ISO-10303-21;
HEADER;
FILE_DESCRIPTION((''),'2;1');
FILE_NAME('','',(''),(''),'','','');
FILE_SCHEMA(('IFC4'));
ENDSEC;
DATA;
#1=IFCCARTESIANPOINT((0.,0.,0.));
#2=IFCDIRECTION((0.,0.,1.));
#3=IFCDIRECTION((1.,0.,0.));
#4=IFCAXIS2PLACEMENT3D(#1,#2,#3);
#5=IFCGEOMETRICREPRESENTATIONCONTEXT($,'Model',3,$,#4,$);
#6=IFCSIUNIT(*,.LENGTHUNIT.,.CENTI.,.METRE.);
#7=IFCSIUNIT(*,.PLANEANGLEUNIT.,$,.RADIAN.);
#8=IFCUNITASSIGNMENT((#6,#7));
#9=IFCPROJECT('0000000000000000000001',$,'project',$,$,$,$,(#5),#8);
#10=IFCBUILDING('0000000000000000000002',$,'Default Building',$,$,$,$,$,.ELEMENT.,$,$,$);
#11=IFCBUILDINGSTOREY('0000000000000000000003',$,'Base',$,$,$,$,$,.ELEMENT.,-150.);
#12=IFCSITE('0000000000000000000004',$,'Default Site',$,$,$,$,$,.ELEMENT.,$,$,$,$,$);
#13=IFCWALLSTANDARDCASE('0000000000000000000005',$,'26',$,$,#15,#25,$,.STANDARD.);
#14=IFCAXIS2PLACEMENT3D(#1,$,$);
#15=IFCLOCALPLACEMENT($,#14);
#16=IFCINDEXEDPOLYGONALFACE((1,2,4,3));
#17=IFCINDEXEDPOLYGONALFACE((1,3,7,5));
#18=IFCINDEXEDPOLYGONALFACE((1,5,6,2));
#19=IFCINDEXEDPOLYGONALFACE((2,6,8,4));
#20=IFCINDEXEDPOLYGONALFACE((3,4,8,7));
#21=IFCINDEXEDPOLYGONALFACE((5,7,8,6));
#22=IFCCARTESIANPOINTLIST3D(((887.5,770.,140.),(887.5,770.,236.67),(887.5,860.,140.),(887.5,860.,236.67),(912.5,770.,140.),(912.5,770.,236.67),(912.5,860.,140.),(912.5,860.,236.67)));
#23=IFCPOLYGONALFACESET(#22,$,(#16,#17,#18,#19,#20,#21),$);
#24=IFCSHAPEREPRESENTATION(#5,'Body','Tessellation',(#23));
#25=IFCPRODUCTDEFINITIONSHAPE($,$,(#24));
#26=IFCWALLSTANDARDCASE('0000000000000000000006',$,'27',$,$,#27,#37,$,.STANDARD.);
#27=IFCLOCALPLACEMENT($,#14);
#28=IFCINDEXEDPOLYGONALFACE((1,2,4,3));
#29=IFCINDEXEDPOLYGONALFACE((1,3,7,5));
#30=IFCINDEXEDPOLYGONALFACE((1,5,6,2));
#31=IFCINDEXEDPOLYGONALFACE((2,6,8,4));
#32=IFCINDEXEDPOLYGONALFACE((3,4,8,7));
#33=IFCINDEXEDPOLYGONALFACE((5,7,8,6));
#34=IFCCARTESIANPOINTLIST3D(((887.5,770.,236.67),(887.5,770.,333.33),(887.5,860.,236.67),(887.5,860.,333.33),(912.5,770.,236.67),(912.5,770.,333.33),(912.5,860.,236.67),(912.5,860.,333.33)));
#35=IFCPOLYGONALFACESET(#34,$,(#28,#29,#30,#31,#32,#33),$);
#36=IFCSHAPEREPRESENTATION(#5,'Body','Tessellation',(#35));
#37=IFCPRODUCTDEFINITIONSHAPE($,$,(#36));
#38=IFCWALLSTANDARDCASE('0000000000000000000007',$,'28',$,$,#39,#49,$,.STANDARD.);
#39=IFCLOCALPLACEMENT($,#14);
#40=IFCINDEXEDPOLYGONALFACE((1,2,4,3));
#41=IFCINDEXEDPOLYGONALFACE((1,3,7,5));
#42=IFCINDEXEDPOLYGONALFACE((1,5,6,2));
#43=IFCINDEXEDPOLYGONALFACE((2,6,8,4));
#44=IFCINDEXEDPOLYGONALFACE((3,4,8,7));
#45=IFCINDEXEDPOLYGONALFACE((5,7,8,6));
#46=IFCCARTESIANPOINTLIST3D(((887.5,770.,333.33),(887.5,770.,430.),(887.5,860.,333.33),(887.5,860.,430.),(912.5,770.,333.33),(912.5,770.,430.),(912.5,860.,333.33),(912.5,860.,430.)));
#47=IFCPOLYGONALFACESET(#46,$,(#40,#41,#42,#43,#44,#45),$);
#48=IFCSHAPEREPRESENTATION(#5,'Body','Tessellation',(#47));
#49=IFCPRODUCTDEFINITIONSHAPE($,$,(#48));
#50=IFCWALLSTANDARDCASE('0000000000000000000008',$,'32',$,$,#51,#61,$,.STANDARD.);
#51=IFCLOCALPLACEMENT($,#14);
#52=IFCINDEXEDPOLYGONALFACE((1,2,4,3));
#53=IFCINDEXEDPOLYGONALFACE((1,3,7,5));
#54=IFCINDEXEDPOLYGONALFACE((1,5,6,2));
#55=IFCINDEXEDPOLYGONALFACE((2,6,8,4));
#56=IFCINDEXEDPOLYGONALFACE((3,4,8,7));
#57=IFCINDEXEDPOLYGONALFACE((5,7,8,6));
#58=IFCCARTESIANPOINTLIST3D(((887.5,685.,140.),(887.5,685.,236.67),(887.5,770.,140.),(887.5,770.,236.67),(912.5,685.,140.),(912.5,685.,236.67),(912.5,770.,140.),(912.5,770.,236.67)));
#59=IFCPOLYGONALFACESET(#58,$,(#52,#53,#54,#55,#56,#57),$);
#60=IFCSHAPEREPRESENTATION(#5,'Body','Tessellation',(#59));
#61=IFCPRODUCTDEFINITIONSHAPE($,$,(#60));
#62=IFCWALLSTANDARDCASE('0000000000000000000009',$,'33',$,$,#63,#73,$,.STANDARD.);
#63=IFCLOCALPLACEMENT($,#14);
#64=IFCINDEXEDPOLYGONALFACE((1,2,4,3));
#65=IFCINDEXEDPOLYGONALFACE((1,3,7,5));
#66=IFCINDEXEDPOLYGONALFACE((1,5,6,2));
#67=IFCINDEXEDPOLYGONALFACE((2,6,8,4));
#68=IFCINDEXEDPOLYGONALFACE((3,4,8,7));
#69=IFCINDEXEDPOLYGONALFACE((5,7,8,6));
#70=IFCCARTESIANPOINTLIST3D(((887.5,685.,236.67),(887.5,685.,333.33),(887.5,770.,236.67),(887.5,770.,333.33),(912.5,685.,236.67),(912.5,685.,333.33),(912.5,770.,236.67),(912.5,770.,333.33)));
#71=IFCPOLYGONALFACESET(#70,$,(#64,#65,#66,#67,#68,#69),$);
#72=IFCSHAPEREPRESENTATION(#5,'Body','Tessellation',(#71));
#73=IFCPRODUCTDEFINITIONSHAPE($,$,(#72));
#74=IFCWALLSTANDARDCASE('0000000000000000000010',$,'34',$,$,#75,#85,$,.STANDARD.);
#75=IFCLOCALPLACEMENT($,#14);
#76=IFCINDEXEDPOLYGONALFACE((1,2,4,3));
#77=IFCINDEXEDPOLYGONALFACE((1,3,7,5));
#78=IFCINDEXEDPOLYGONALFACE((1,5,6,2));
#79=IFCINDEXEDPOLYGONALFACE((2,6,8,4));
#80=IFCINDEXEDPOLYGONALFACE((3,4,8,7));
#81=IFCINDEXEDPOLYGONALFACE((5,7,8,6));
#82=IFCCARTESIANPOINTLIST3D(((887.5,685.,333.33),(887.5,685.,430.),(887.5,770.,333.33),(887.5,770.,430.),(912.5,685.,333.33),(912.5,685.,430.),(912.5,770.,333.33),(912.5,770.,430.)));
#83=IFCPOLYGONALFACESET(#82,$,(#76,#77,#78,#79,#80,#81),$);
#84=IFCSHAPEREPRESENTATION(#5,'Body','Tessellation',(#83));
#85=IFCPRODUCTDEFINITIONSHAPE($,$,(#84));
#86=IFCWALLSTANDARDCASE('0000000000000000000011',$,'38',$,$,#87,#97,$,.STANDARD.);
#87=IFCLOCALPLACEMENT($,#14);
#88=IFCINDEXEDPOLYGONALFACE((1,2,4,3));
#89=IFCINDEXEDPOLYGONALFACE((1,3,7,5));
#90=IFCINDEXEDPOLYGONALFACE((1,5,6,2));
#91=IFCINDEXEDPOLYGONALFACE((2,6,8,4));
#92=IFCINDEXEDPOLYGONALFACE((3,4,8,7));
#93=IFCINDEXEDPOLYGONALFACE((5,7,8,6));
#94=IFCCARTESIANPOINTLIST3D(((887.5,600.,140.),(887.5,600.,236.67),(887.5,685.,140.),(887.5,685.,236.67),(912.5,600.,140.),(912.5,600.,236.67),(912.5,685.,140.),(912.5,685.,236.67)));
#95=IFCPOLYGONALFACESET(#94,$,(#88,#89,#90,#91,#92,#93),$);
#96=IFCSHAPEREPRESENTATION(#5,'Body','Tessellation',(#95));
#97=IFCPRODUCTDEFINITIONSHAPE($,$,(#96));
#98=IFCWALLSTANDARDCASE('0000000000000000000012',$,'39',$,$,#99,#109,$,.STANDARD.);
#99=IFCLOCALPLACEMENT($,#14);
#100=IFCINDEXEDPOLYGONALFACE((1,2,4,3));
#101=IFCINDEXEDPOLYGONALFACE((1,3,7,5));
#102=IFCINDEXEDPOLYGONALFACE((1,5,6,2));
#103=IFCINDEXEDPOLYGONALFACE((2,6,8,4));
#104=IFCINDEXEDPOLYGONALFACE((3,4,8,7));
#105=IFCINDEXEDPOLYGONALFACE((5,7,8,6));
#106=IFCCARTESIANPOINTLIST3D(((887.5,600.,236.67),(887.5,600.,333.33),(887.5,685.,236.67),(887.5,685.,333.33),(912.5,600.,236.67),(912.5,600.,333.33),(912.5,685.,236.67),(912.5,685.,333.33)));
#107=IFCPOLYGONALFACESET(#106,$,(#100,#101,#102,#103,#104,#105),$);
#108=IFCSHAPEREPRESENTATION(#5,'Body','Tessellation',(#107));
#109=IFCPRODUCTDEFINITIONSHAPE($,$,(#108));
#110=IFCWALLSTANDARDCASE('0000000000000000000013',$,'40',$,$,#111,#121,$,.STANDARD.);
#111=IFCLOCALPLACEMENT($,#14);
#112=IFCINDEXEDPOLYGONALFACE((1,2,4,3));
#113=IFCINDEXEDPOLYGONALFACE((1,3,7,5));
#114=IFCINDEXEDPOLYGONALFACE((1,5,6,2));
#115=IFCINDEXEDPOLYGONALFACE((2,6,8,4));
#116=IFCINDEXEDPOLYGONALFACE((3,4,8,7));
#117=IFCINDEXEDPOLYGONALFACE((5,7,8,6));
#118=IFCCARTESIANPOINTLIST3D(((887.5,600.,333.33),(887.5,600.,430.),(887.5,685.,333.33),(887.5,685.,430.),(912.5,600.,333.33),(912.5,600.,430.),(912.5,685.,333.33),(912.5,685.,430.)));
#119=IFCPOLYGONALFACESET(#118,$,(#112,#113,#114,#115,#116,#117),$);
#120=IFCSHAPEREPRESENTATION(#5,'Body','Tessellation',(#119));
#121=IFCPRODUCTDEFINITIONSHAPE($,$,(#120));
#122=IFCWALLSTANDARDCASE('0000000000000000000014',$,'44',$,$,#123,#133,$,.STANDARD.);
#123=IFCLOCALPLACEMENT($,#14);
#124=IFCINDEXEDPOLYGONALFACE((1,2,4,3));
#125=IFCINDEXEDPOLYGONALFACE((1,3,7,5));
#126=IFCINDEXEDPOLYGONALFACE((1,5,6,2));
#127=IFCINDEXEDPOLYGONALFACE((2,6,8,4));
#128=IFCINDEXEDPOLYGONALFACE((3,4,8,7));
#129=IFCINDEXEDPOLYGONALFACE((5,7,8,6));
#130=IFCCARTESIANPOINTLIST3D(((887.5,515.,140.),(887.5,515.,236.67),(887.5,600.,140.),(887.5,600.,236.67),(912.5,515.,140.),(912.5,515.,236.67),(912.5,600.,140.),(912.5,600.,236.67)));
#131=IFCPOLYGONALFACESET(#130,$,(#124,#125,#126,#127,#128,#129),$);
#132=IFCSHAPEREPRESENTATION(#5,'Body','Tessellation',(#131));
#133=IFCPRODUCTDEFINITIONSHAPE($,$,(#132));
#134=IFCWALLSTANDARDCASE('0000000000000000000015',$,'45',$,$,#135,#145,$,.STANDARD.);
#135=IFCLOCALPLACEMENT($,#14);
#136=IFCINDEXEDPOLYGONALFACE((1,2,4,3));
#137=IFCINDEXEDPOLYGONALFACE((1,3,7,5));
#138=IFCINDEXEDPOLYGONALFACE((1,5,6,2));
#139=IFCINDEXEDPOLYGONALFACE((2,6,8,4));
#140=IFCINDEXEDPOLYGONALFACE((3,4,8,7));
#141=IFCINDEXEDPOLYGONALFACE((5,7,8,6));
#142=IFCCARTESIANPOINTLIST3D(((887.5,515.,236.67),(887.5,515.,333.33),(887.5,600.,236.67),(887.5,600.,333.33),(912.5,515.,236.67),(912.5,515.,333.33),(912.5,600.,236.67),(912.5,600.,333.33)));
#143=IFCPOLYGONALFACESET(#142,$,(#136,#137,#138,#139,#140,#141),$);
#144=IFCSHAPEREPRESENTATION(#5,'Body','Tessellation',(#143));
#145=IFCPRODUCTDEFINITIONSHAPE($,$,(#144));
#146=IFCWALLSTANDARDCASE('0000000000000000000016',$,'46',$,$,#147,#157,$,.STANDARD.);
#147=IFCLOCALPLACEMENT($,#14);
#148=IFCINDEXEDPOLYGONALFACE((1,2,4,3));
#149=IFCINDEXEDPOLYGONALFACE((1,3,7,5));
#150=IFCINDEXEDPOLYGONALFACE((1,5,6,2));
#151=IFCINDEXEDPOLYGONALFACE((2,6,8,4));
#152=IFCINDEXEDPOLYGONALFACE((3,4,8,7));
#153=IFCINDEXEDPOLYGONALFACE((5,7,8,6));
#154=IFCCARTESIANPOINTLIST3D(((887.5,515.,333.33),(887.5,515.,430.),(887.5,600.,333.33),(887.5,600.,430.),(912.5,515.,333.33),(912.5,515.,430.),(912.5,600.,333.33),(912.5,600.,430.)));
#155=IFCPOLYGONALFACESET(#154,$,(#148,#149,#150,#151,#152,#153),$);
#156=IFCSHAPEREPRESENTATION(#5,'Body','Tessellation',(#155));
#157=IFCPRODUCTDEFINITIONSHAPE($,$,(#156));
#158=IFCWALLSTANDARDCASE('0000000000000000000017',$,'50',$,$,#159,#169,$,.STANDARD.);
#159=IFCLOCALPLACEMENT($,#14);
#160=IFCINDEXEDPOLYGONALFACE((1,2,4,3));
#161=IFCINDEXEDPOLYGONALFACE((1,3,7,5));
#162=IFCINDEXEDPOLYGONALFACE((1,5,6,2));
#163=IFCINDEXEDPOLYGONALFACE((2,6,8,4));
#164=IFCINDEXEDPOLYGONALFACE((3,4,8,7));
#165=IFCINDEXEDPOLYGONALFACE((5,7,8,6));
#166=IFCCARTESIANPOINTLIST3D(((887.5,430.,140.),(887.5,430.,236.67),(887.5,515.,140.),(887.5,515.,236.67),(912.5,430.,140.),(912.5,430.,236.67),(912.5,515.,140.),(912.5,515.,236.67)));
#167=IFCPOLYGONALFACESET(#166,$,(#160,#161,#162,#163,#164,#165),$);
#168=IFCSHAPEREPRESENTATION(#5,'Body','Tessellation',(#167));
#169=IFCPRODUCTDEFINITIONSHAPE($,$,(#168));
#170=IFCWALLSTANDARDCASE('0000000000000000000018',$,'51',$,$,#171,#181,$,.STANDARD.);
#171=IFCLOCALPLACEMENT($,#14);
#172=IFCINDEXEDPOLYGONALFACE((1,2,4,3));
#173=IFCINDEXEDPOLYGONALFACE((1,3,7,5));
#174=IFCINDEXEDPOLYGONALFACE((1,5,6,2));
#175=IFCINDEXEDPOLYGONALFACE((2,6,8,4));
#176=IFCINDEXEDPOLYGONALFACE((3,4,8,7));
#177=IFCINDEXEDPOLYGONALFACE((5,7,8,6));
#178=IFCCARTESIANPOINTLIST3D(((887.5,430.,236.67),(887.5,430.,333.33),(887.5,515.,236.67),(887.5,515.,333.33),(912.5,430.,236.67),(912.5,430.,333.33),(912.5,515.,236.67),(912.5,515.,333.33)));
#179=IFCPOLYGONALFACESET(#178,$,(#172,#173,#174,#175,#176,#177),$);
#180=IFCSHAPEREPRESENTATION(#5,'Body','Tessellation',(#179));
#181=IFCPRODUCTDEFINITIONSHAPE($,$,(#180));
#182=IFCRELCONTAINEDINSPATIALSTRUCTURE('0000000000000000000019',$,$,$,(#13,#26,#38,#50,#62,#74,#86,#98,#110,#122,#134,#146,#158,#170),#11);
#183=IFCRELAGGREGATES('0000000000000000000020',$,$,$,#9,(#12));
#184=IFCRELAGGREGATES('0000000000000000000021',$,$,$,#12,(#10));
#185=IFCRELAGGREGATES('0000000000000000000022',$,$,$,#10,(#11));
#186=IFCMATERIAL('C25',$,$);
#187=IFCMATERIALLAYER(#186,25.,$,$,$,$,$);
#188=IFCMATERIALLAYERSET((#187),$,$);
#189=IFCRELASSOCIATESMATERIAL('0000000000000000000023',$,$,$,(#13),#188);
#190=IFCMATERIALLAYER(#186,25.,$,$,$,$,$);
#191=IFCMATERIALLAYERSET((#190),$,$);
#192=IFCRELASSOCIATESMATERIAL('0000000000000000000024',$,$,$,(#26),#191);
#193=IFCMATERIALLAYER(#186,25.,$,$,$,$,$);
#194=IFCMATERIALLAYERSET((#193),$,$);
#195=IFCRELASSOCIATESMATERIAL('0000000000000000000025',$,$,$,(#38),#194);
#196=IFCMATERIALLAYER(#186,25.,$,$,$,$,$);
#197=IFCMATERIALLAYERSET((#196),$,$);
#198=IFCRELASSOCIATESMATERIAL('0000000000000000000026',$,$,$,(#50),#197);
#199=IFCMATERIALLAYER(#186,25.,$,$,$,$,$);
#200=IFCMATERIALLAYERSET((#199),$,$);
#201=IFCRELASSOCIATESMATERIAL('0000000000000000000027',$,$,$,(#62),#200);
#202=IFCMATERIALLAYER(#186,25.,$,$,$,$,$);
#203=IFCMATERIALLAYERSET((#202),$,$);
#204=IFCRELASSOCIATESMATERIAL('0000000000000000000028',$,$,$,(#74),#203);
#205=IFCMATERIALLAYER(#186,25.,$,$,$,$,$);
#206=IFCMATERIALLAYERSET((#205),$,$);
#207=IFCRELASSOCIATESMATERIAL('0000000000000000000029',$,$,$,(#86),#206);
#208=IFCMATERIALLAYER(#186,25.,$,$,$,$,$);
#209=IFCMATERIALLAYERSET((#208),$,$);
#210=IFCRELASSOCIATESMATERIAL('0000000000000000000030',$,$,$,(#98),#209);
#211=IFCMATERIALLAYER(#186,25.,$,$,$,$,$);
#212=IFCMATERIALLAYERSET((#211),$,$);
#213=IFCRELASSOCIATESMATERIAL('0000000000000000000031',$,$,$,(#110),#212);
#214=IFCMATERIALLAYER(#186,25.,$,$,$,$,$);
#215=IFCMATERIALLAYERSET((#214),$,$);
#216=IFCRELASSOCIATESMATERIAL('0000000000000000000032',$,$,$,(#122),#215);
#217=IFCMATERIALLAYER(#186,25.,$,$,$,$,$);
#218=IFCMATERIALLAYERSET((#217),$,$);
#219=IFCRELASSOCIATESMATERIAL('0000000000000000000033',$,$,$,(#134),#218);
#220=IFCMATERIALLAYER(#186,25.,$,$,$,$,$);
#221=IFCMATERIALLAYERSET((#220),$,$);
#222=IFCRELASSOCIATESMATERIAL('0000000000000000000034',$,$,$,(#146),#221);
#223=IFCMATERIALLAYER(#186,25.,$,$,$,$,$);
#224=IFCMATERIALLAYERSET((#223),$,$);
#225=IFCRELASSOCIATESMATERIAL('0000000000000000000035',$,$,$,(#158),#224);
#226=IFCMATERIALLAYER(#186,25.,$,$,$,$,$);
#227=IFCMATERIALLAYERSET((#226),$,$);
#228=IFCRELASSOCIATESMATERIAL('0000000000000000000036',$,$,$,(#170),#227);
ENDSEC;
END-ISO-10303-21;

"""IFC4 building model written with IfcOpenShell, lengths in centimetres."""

from ifc_helpers import new_model, si_unit, frame, origin_with_axes, origin_2d_with_axis, place, context, project, spatial, rectangle, extrude, material, layer, layer_set, layer_usage, element, save


model = new_model("IFC4")

# Units and contexts
model_context = context("Model", 3, world=origin_with_axes())
ifc_project = project(units=[si_unit("LENGTHUNIT", "METRE", prefix="CENTI"), si_unit("PLANEANGLEUNIT", "RADIAN")], contexts=[model_context])

# Site, building, storey
site = spatial("IfcSite", under=ifc_project, Name="Default Site", CompositionType="ELEMENT")
building = spatial("IfcBuilding", under=site, Name="Default Building", CompositionType="ELEMENT")
storey = spatial("IfcBuildingStorey", under=building, Name="Base", CompositionType="ELEMENT", Elevation=-150.0)

# Walls
ifc_material = material(Name="C25")
ifc_layer_1 = layer(ifc_material, 25.0)
ifc_layer_set_1 = layer_set([ifc_layer_1])
ifc_layer_usage_1 = layer_usage(ifc_layer_set_1, "AXIS2", "POSITIVE", -25.0)
wall_1_placement = place(None, frame((900.0, 815.0, 140.0), z_axis=(0.0, 0.0, 1.0), x_axis=(0.0, -1.0, 0.0)))
element("IfcWallStandardCase", 1, at=wall_1_placement, inside=storey, material=ifc_layer_usage_1, Name="26", PredefinedType="STANDARD", context=model_context, shape_type="SweptSolid", body=[
    extrude(rectangle(XDim=90.0, YDim=25.0, at=origin_2d_with_axis()), origin_with_axes(), (0.0, 0.0, 1.0), 96.67),
])
ifc_layer_2 = layer(ifc_material, 25.0)
ifc_layer_set_2 = layer_set([ifc_layer_2])
ifc_layer_usage_2 = layer_usage(ifc_layer_set_2, "AXIS2", "POSITIVE", -25.0)
wall_2_placement = place(None, frame((900.0, 815.0, 236.67), z_axis=(0.0, 0.0, 1.0), x_axis=(0.0, -1.0, 0.0)))
element("IfcWallStandardCase", 2, at=wall_2_placement, inside=storey, material=ifc_layer_usage_2, Name="27", PredefinedType="STANDARD", context=model_context, shape_type="SweptSolid", body=[
    extrude(rectangle(XDim=90.0, YDim=25.0, at=origin_2d_with_axis()), origin_with_axes(), (0.0, 0.0, 1.0), 96.67),
])
ifc_layer_3 = layer(ifc_material, 25.0)
ifc_layer_set_3 = layer_set([ifc_layer_3])
ifc_layer_usage_3 = layer_usage(ifc_layer_set_3, "AXIS2", "POSITIVE", -25.0)
wall_3_placement = place(None, frame((900.0, 815.0, 333.33), z_axis=(0.0, 0.0, 1.0), x_axis=(0.0, -1.0, 0.0)))
element("IfcWallStandardCase", 3, at=wall_3_placement, inside=storey, material=ifc_layer_usage_3, Name="28", PredefinedType="STANDARD", context=model_context, shape_type="SweptSolid", body=[
    extrude(rectangle(XDim=90.0, YDim=25.0, at=origin_2d_with_axis()), origin_with_axes(), (0.0, 0.0, 1.0), 96.67),
])
ifc_layer_4 = layer(ifc_material, 25.0)
ifc_layer_set_4 = layer_set([ifc_layer_4])
ifc_layer_usage_4 = layer_usage(ifc_layer_set_4, "AXIS2", "POSITIVE", -25.0)
wall_4_placement = place(None, frame((900.0, 727.5, 140.0), z_axis=(0.0, 0.0, 1.0), x_axis=(0.0, -1.0, 0.0)))
element("IfcWallStandardCase", 4, at=wall_4_placement, inside=storey, material=ifc_layer_usage_4, Name="32", PredefinedType="STANDARD", context=model_context, shape_type="SweptSolid", body=[
    extrude(rectangle(XDim=85.0, YDim=25.0, at=origin_2d_with_axis()), origin_with_axes(), (0.0, 0.0, 1.0), 96.67),
])
ifc_layer_5 = layer(ifc_material, 25.0)
ifc_layer_set_5 = layer_set([ifc_layer_5])
ifc_layer_usage_5 = layer_usage(ifc_layer_set_5, "AXIS2", "POSITIVE", -25.0)
wall_5_placement = place(None, frame((900.0, 727.5, 236.67), z_axis=(0.0, 0.0, 1.0), x_axis=(0.0, -1.0, 0.0)))
element("IfcWallStandardCase", 5, at=wall_5_placement, inside=storey, material=ifc_layer_usage_5, Name="33", PredefinedType="STANDARD", context=model_context, shape_type="SweptSolid", body=[
    extrude(rectangle(XDim=85.0, YDim=25.0, at=origin_2d_with_axis()), origin_with_axes(), (0.0, 0.0, 1.0), 96.67),
])
ifc_layer_6 = layer(ifc_material, 25.0)
ifc_layer_set_6 = layer_set([ifc_layer_6])
ifc_layer_usage_6 = layer_usage(ifc_layer_set_6, "AXIS2", "POSITIVE", -25.0)
wall_6_placement = place(None, frame((900.0, 727.5, 333.33), z_axis=(0.0, 0.0, 1.0), x_axis=(0.0, -1.0, 0.0)))
element("IfcWallStandardCase", 6, at=wall_6_placement, inside=storey, material=ifc_layer_usage_6, Name="34", PredefinedType="STANDARD", context=model_context, shape_type="SweptSolid", body=[
    extrude(rectangle(XDim=85.0, YDim=25.0, at=origin_2d_with_axis()), origin_with_axes(), (0.0, 0.0, 1.0), 96.67),
])
ifc_layer_7 = layer(ifc_material, 25.0)
ifc_layer_set_7 = layer_set([ifc_layer_7])
ifc_layer_usage_7 = layer_usage(ifc_layer_set_7, "AXIS2", "POSITIVE", -25.0)
wall_7_placement = place(None, frame((900.0, 642.5, 140.0), z_axis=(0.0, 0.0, 1.0), x_axis=(0.0, -1.0, 0.0)))
element("IfcWallStandardCase", 7, at=wall_7_placement, inside=storey, material=ifc_layer_usage_7, Name="38", PredefinedType="STANDARD", context=model_context, shape_type="SweptSolid", body=[
    extrude(rectangle(XDim=85.0, YDim=25.0, at=origin_2d_with_axis()), origin_with_axes(), (0.0, 0.0, 1.0), 96.67),
])
ifc_layer_8 = layer(ifc_material, 25.0)
ifc_layer_set_8 = layer_set([ifc_layer_8])
ifc_layer_usage_8 = layer_usage(ifc_layer_set_8, "AXIS2", "POSITIVE", -25.0)
wall_8_placement = place(None, frame((900.0, 642.5, 236.67), z_axis=(0.0, 0.0, 1.0), x_axis=(0.0, -1.0, 0.0)))
element("IfcWallStandardCase", 8, at=wall_8_placement, inside=storey, material=ifc_layer_usage_8, Name="39", PredefinedType="STANDARD", context=model_context, shape_type="SweptSolid", body=[
    extrude(rectangle(XDim=85.0, YDim=25.0, at=origin_2d_with_axis()), origin_with_axes(), (0.0, 0.0, 1.0), 96.67),
])
ifc_layer_9 = layer(ifc_material, 25.0)
ifc_layer_set_9 = layer_set([ifc_layer_9])
ifc_layer_usage_9 = layer_usage(ifc_layer_set_9, "AXIS2", "POSITIVE", -25.0)
wall_9_placement = place(None, frame((900.0, 642.5, 333.33), z_axis=(0.0, 0.0, 1.0), x_axis=(0.0, -1.0, 0.0)))
element("IfcWallStandardCase", 9, at=wall_9_placement, inside=storey, material=ifc_layer_usage_9, Name="40", PredefinedType="STANDARD", context=model_context, shape_type="SweptSolid", body=[
    extrude(rectangle(XDim=85.0, YDim=25.0, at=origin_2d_with_axis()), origin_with_axes(), (0.0, 0.0, 1.0), 96.67),
])
ifc_layer_10 = layer(ifc_material, 25.0)
ifc_layer_set_10 = layer_set([ifc_layer_10])
ifc_layer_usage_10 = layer_usage(ifc_layer_set_10, "AXIS2", "POSITIVE", -25.0)
wall_10_placement = place(None, frame((900.0, 557.5, 140.0), z_axis=(0.0, 0.0, 1.0), x_axis=(0.0, -1.0, 0.0)))
element("IfcWallStandardCase", 10, at=wall_10_placement, inside=storey, material=ifc_layer_usage_10, Name="44", PredefinedType="STANDARD", context=model_context, shape_type="SweptSolid", body=[
    extrude(rectangle(XDim=85.0, YDim=25.0, at=origin_2d_with_axis()), origin_with_axes(), (0.0, 0.0, 1.0), 96.67),
])
ifc_layer_11 = layer(ifc_material, 25.0)
ifc_layer_set_11 = layer_set([ifc_layer_11])
ifc_layer_usage_11 = layer_usage(ifc_layer_set_11, "AXIS2", "POSITIVE", -25.0)
wall_11_placement = place(None, frame((900.0, 557.5, 236.67), z_axis=(0.0, 0.0, 1.0), x_axis=(0.0, -1.0, 0.0)))
element("IfcWallStandardCase", 11, at=wall_11_placement, inside=storey, material=ifc_layer_usage_11, Name="45", PredefinedType="STANDARD", context=model_context, shape_type="SweptSolid", body=[
    extrude(rectangle(XDim=85.0, YDim=25.0, at=origin_2d_with_axis()), origin_with_axes(), (0.0, 0.0, 1.0), 96.67),
])
ifc_layer_12 = layer(ifc_material, 25.0)
ifc_layer_set_12 = layer_set([ifc_layer_12])
ifc_layer_usage_12 = layer_usage(ifc_layer_set_12, "AXIS2", "POSITIVE", -25.0)
wall_12_placement = place(None, frame((900.0, 557.5, 333.33), z_axis=(0.0, 0.0, 1.0), x_axis=(0.0, -1.0, 0.0)))
element("IfcWallStandardCase", 12, at=wall_12_placement, inside=storey, material=ifc_layer_usage_12, Name="46", PredefinedType="STANDARD", context=model_context, shape_type="SweptSolid", body=[
    extrude(rectangle(XDim=85.0, YDim=25.0, at=origin_2d_with_axis()), origin_with_axes(), (0.0, 0.0, 1.0), 96.67),
])
ifc_layer_13 = layer(ifc_material, 25.0)
ifc_layer_set_13 = layer_set([ifc_layer_13])
ifc_layer_usage_13 = layer_usage(ifc_layer_set_13, "AXIS2", "POSITIVE", -25.0)
wall_13_placement = place(None, frame((900.0, 472.5, 140.0), z_axis=(0.0, 0.0, 1.0), x_axis=(0.0, -1.0, 0.0)))
element("IfcWallStandardCase", 13, at=wall_13_placement, inside=storey, material=ifc_layer_usage_13, Name="50", PredefinedType="STANDARD", context=model_context, shape_type="SweptSolid", body=[
    extrude(rectangle(XDim=85.0, YDim=25.0, at=origin_2d_with_axis()), origin_with_axes(), (0.0, 0.0, 1.0), 96.67),
])
ifc_layer_14 = layer(ifc_material, 25.0)
ifc_layer_set_14 = layer_set([ifc_layer_14])
ifc_layer_usage_14 = layer_usage(ifc_layer_set_14, "AXIS2", "POSITIVE", -25.0)
wall_14_placement = place(None, frame((900.0, 472.5, 236.67), z_axis=(0.0, 0.0, 1.0), x_axis=(0.0, -1.0, 0.0)))
element("IfcWallStandardCase", 14, at=wall_14_placement, inside=storey, material=ifc_layer_usage_14, Name="51", PredefinedType="STANDARD", context=model_context, shape_type="SweptSolid", body=[
    extrude(rectangle(XDim=85.0, YDim=25.0, at=origin_2d_with_axis()), origin_with_axes(), (0.0, 0.0, 1.0), 96.67),
])

save(model, "model.ifc")
